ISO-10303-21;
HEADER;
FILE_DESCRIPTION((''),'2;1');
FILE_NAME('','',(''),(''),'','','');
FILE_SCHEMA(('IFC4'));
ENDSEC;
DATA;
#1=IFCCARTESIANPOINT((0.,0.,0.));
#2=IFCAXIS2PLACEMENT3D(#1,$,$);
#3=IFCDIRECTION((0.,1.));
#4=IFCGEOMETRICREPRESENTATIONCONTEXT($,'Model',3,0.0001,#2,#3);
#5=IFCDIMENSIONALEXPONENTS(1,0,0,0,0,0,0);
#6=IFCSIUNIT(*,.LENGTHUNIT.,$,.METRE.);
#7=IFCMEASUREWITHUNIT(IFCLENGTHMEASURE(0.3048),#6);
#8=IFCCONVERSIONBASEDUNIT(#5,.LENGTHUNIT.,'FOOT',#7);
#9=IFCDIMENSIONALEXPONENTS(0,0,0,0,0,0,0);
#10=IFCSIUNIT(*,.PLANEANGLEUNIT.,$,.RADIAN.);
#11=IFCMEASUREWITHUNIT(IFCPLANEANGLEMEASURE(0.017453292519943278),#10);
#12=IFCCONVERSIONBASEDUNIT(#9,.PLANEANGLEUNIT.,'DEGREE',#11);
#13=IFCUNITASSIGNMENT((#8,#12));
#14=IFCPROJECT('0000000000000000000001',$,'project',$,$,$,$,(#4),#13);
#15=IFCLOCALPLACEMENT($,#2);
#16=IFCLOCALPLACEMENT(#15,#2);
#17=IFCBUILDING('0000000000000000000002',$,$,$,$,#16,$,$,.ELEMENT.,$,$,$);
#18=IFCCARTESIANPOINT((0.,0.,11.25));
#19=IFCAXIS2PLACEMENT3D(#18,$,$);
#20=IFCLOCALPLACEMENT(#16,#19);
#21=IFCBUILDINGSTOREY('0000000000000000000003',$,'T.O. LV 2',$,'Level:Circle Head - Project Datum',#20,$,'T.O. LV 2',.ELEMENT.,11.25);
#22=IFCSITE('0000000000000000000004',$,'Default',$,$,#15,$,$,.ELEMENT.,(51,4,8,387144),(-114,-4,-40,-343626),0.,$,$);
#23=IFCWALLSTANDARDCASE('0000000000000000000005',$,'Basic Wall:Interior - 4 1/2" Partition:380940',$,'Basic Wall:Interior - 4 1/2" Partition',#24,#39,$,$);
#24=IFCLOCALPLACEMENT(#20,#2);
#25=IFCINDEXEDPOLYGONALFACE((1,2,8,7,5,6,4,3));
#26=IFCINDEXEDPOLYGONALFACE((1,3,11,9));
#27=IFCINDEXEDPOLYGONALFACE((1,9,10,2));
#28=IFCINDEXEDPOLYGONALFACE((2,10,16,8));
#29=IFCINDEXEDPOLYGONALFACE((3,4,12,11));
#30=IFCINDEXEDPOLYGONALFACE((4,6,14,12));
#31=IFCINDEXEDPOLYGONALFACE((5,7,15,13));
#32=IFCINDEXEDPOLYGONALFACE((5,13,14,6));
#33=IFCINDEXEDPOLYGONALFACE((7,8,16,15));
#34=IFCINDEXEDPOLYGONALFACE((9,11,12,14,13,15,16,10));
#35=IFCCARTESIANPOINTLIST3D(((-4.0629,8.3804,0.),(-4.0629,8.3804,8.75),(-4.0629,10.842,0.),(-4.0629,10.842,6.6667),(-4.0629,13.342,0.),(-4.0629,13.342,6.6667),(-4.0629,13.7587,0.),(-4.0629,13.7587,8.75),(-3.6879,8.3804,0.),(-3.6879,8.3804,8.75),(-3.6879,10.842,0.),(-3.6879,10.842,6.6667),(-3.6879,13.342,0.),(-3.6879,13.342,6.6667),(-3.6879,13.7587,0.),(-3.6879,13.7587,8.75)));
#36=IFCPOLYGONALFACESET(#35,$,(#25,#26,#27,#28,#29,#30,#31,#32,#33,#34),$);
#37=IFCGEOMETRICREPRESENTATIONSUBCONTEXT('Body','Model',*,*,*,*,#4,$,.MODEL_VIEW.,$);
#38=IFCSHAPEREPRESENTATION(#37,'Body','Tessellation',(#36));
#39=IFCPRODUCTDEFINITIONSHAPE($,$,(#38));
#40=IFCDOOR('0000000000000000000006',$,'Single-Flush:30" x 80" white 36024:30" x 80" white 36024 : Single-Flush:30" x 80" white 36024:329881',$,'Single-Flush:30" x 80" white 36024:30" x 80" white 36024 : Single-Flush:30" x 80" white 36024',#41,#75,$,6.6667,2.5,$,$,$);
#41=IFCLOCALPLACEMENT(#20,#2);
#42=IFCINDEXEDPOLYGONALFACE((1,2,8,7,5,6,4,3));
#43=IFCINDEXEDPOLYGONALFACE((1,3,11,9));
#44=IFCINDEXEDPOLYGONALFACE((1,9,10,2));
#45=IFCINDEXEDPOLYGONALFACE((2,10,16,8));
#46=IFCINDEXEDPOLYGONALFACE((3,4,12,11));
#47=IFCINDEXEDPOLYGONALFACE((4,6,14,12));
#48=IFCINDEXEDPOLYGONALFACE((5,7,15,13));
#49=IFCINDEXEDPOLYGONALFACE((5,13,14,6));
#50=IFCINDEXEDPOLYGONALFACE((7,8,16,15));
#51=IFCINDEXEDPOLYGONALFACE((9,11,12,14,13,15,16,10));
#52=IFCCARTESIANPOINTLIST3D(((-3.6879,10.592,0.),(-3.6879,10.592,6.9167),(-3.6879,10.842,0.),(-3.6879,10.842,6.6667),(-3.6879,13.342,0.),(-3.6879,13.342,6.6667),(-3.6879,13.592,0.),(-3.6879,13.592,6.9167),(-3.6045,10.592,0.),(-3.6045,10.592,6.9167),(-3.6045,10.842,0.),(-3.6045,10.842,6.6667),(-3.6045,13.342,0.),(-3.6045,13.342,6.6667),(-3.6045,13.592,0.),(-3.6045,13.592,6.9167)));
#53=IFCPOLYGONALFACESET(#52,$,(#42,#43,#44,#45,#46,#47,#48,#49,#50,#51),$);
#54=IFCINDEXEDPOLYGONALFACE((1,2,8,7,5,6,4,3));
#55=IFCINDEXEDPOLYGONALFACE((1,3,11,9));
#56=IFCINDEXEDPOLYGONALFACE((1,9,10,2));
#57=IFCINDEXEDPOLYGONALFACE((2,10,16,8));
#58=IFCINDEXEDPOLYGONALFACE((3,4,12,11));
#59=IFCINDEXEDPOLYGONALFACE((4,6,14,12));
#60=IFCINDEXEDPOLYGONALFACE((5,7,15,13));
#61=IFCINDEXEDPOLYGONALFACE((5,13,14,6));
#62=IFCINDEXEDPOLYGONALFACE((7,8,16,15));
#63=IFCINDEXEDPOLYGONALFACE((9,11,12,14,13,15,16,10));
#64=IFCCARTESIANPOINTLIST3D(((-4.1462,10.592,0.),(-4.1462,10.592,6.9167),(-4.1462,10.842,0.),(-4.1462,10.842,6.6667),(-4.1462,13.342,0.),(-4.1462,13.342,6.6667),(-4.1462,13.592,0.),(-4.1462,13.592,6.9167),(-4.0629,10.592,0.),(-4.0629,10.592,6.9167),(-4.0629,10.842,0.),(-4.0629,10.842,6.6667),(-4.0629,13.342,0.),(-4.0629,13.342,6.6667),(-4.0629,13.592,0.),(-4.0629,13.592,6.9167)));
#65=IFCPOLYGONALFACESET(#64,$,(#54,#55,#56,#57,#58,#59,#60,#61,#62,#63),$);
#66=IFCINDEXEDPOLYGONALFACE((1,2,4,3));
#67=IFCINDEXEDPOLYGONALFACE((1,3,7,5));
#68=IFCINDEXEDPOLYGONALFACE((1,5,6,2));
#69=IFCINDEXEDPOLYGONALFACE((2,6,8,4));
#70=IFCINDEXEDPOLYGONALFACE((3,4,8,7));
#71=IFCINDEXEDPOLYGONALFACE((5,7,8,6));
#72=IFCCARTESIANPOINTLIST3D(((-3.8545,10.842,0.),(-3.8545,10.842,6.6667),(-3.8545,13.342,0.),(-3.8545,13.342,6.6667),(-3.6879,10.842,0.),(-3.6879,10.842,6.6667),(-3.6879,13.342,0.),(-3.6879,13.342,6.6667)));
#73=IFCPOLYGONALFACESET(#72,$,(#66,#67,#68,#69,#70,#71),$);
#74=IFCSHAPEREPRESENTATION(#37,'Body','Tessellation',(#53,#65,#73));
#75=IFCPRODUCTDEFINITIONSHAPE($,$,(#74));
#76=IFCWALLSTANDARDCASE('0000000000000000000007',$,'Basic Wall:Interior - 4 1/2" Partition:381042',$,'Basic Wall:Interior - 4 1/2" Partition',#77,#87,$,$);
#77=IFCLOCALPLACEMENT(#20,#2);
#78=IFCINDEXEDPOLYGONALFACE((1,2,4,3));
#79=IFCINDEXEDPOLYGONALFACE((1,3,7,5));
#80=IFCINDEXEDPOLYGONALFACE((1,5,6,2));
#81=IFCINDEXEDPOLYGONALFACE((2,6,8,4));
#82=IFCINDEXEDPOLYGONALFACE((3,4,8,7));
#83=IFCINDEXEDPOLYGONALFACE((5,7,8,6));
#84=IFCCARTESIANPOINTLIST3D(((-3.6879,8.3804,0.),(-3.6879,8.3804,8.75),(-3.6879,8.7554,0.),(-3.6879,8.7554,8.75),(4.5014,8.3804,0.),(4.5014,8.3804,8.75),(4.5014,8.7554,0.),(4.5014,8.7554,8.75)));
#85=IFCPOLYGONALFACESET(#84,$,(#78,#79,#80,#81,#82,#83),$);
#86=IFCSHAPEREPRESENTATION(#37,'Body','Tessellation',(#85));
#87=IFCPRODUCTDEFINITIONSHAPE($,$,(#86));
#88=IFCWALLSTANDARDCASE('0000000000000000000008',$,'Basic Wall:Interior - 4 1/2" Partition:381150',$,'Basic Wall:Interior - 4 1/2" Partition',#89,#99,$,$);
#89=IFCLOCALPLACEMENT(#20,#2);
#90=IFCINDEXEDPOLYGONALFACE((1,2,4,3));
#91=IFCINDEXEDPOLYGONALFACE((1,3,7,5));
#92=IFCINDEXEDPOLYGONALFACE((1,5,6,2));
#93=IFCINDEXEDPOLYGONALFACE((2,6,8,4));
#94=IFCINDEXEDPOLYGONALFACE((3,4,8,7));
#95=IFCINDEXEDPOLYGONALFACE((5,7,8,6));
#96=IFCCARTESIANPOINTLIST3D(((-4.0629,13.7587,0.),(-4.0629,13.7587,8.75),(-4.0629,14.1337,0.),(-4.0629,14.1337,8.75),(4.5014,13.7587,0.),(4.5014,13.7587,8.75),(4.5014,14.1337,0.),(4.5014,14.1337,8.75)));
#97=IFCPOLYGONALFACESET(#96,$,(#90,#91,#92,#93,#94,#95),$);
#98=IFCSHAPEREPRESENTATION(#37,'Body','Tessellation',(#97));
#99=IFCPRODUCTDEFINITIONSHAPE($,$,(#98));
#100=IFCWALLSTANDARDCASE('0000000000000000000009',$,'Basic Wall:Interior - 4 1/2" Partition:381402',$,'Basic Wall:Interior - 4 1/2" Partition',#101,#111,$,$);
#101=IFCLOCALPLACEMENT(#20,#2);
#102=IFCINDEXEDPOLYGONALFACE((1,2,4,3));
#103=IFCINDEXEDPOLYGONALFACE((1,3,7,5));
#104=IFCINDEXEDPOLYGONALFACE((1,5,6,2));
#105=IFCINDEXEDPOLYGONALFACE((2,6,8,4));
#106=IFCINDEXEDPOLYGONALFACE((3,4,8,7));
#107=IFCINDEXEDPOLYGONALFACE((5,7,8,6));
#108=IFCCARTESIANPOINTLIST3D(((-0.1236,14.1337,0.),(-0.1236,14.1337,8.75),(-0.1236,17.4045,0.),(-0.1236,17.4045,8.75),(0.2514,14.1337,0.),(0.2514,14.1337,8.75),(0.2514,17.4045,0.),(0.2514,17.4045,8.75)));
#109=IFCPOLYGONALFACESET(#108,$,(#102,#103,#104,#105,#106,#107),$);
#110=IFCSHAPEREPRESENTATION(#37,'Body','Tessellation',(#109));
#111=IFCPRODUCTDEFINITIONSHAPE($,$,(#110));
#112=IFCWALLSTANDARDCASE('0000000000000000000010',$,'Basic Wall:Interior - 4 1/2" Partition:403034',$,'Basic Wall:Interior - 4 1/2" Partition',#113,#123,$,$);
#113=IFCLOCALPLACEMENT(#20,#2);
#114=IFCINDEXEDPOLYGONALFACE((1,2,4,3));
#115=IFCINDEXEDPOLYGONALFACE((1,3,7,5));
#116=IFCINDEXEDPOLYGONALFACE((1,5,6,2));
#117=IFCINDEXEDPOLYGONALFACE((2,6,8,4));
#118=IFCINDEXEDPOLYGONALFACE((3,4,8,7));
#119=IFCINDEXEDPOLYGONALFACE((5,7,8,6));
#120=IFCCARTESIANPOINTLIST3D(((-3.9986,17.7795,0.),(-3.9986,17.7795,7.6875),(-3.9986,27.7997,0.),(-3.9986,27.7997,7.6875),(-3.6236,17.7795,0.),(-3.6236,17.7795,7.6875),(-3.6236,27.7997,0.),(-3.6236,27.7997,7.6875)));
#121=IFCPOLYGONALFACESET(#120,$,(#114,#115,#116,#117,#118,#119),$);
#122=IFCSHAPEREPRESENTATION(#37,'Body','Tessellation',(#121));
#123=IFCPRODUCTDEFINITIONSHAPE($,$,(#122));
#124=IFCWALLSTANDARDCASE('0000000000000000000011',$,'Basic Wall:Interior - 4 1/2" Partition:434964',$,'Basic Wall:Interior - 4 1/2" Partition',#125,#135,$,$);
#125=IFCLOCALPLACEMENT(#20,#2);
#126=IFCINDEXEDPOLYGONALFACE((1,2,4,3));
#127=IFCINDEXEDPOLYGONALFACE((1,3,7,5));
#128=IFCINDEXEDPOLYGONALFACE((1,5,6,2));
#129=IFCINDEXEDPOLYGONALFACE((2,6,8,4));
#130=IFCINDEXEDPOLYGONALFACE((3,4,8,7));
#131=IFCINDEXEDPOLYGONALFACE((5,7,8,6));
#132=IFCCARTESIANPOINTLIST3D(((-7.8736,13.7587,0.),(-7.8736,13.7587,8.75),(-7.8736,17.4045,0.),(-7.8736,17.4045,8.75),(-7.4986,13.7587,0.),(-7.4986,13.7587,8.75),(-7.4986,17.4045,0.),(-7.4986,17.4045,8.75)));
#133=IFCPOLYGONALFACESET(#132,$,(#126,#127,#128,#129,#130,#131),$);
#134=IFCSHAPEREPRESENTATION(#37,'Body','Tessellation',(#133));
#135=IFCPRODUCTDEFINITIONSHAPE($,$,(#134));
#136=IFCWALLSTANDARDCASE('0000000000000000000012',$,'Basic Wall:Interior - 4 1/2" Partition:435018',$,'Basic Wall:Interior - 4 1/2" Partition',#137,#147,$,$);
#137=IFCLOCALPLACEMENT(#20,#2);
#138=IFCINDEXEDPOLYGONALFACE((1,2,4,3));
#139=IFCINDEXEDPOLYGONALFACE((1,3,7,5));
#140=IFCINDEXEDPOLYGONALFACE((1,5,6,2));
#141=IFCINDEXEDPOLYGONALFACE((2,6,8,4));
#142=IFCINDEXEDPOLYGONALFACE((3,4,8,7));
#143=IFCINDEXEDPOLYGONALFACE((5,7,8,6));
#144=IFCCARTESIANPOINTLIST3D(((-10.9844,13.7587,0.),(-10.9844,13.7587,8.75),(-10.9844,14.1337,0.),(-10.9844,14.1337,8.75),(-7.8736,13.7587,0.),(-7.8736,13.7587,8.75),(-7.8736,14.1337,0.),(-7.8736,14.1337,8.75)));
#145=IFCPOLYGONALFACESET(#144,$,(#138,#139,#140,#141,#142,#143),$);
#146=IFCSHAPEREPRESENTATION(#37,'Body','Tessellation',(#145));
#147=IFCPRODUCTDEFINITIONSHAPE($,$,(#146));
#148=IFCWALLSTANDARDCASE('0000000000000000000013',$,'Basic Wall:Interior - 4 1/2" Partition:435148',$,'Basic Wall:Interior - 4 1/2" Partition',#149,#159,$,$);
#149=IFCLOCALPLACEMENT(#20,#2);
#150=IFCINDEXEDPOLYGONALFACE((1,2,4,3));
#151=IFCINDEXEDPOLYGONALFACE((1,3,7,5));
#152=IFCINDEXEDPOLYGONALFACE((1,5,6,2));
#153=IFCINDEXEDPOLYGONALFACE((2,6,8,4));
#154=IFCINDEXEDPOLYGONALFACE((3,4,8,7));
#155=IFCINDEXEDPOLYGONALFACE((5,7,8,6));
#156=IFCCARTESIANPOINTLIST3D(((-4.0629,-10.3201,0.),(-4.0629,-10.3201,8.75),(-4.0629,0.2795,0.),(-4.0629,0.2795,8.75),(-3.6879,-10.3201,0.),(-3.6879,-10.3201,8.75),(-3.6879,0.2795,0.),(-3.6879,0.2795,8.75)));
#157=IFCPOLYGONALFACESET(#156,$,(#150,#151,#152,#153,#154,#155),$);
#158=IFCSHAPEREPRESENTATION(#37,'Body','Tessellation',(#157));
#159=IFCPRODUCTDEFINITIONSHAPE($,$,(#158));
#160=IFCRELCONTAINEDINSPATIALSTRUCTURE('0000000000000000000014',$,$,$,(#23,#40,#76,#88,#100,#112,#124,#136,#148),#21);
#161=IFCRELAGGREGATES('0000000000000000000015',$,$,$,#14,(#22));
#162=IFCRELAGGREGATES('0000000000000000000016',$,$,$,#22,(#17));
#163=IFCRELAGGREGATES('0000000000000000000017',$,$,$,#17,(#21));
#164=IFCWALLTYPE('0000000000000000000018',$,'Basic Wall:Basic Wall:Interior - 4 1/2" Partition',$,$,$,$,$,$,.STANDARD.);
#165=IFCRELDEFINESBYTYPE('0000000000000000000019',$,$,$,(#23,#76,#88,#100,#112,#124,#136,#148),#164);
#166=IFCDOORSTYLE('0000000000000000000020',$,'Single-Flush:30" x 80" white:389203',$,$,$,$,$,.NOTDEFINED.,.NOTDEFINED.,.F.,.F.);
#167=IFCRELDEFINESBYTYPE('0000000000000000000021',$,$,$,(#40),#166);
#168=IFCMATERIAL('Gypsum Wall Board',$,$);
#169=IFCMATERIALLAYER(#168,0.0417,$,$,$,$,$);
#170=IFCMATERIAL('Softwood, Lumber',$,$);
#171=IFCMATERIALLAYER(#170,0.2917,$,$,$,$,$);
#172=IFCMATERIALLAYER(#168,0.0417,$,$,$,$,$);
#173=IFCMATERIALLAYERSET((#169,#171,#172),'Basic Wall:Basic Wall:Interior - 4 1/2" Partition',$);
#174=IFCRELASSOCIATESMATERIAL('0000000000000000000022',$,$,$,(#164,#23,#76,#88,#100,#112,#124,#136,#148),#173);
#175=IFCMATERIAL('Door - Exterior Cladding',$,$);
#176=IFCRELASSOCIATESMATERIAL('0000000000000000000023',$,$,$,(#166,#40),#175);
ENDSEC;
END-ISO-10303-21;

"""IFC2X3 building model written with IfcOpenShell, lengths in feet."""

from ifc_helpers import new_model, entity, si_unit, converted_unit, direction, frame, frame_2d, origin, origin_2d_with_axis, place, context, subcontext, project, spatial, polyline, rectangle, outline, extrude, source, transform, mapped, material, layer, layer_set, layer_usage, type_object, type_shapes, element, fill, save


model = new_model("IFC2X3")

# Units and contexts
model_context = context("Model", 3, precision=0.0001, world=origin(), true_north=direction((0.0, 1.0)))
body_context = subcontext(model_context, "Body", "Model", "MODEL_VIEW")
ifc_project = project(units=[converted_unit("LENGTHUNIT", "FOOT", entity("IfcLengthMeasure", 0.3048), si_unit("LENGTHUNIT", "METRE"), dimensions=[1, 0, 0, 0, 0, 0, 0]), converted_unit("PLANEANGLEUNIT", "DEGREE", entity("IfcPlaneAngleMeasure", 0.017453292519943278), si_unit("PLANEANGLEUNIT", "RADIAN"), dimensions=[0, 0, 0, 0, 0, 0, 0])], contexts=[model_context])

# Site, building, storey
site_placement = place(None, origin())
site = spatial("IfcSite", under=ifc_project, at=site_placement, Name="Default", CompositionType="ELEMENT", RefLatitude=(51, 4, 8, 387144), RefLongitude=(-114, -4, -40, -343626), RefElevation=0.0)
building_placement = place(site_placement, origin())
building = spatial("IfcBuilding", under=site, at=building_placement, CompositionType="ELEMENT")
storey_placement = place(building_placement, frame((0.0, 0.0, 11.25)))
storey = spatial("IfcBuildingStorey", under=building, at=storey_placement, Name="T.O. LV 2", ObjectType="Level:Circle Head - Project Datum", LongName="T.O. LV 2", CompositionType="ELEMENT", Elevation=11.25)

# Shared definitions
ifc_material_1 = material(Name="Gypsum Wall Board")
ifc_layer_1 = layer(ifc_material_1, 0.0417)
ifc_material_2 = material(Name="Softwood, Lumber")
ifc_layer_2 = layer(ifc_material_2, 0.2917)
ifc_layer_3 = layer(ifc_material_1, 0.0417)
ifc_layer_set_1 = layer_set([ifc_layer_1, ifc_layer_2, ifc_layer_3], Name="Basic Wall:Basic Wall:Interior - 4 1/2\" Partition")
wall_type_1 = type_object("IfcWallType", Name="Basic Wall:Basic Wall:Interior - 4 1/2\" Partition", PredefinedType="STANDARD", material=ifc_layer_set_1)

# Wall, opening, door
ifc_layer_usage_1 = layer_usage(ifc_layer_set_1, "AXIS2", "NEGATIVE", 0.1875)
wall_1_placement = place(storey_placement, frame((-3.8754, 13.7587, 0.0), z_axis=(0.0, 0.0, 1.0), x_axis=(0.0, -1.0, 0.0)))
wall_1 = element("IfcWallStandardCase", 1, at=wall_1_placement, inside=storey, type_object=wall_type_1, material=ifc_layer_usage_1, Name="Basic Wall:Interior - 4 1/2\" Partition:380940", ObjectType="Basic Wall:Interior - 4 1/2\" Partition", context=body_context, shape_type="SweptSolid", body=[
    extrude(rectangle(XDim=5.3783, YDim=0.375, at=frame_2d((2.6891, 0.0), x_axis=(1.0, 0.0))), origin(), (0.0, 0.0, 1.0), 8.75),
])
opening_1_placement = place(wall_1_placement, frame((13.7587, 3.8754, 0.0), z_axis=(0.0, 0.0, 1.0), x_axis=(0.0, 1.0, 0.0)))
opening_1 = element("IfcOpeningElement", 2, at=opening_1_placement, cuts=wall_1, ObjectType="Opening", context=body_context, shape_type="SweptSolid", body=[
    extrude(rectangle(XDim=6.6667, YDim=2.5, at=frame_2d((0.0, 0.0), x_axis=(1.0, 0.0))), frame((-4.0666, 12.092, 3.3333), z_axis=(1.0, 0.0, 0.0), x_axis=(0.0, 0.0, 1.0)), (0.0, 0.0, 1.0), 0.3825),
])
ifc_material_3 = material(Name="Door - Exterior Cladding")
door_style_1 = type_object("IfcDoorStyle", Name="Single-Flush:30\" x 80\" white:389203", ConstructionType="NOTDEFINED", OperationType="NOTDEFINED", ParameterTakesPrecedence=False, Sizeable=False, material=ifc_material_3)
shared_shape_1 = source(origin(), body_context, "Body", "SweptSolid", [
    extrude(outline(polyline([(-1.5, -3.5208), (1.5, -3.5208), (1.5, 3.3958), (1.25, 3.3958), (1.25, -3.2708), (-1.25, -3.2708), (-1.25, 3.3958), (-1.5, 3.3958), (-1.5, -3.5208)])), frame((1.25, -0.0038, 3.3958), z_axis=(0.0, 1.0, 0.0), x_axis=(1.0, 0.0, 0.0)), (0.0, 0.0, 1.0), 0.0833),
    extrude(outline(polyline([(-3.3958, -1.5), (3.5208, -1.5), (3.5208, 1.5), (-3.3958, 1.5), (-3.3958, 1.25), (3.2708, 1.25), (3.2708, -1.25), (-3.3958, -1.25), (-3.3958, -1.5)])), frame((1.25, -0.4621, 3.3958), z_axis=(0.0, 1.0, 0.0), x_axis=(0.0, 0.0, 1.0)), (0.0, 0.0, 1.0), 0.0833),
    extrude(rectangle(XDim=0.1667, YDim=2.5, at=origin_2d_with_axis()), frame((1.25, -0.0871, 0.0), z_axis=(0.0, 0.0, 1.0), x_axis=(0.0, 1.0, 0.0)), (0.0, 0.0, 1.0), 6.6667),
])
type_shapes(door_style_1, [shared_shape_1])
door_1_placement = place(opening_1_placement, frame((-3.6841, 13.342, 0.0), z_axis=(0.0, 0.0, 1.0), x_axis=(0.0, -1.0, 0.0)))
door_1 = element("IfcDoor", 3, at=door_1_placement, inside=storey, type_object=door_style_1, material=ifc_material_3, Name="Single-Flush:30\" x 80\" white 36024:30\" x 80\" white 36024 : Single-Flush:30\" x 80\" white 36024:329881", ObjectType="Single-Flush:30\" x 80\" white 36024:30\" x 80\" white 36024 : Single-Flush:30\" x 80\" white 36024", OverallHeight=6.6667, OverallWidth=2.5, context=body_context, shape_type="MappedRepresentation", body=[
    mapped(shared_shape_1, transform((0.0, 0.0, 0.0), scale=1.0)),
])
fill(opening_1, door_1)

# Walls
ifc_layer_usage_2 = layer_usage(ifc_layer_set_1, "AXIS2", "NEGATIVE", 0.1875)
wall_2_placement = place(storey_placement, frame((-3.6879, 8.5679, 0.0)))
element("IfcWallStandardCase", 4, at=wall_2_placement, inside=storey, type_object=wall_type_1, material=ifc_layer_usage_2, Name="Basic Wall:Interior - 4 1/2\" Partition:381042", ObjectType="Basic Wall:Interior - 4 1/2\" Partition", context=body_context, shape_type="SweptSolid", body=[
    extrude(rectangle(XDim=8.1893, YDim=0.375, at=frame_2d((4.0947, 0.0), x_axis=(-1.0, 0.0))), origin(), (0.0, 0.0, 1.0), 8.75),
])
ifc_layer_usage_3 = layer_usage(ifc_layer_set_1, "AXIS2", "NEGATIVE", 0.1875)
wall_3_placement = place(storey_placement, frame((-4.0629, 13.9462, 0.0)))
element("IfcWallStandardCase", 5, at=wall_3_placement, inside=storey, type_object=wall_type_1, material=ifc_layer_usage_3, Name="Basic Wall:Interior - 4 1/2\" Partition:381150", ObjectType="Basic Wall:Interior - 4 1/2\" Partition", context=body_context, shape_type="SweptSolid", body=[
    extrude(rectangle(XDim=8.5643, YDim=0.375, at=frame_2d((4.2822, 0.0), x_axis=(-1.0, 0.0))), origin(), (0.0, 0.0, 1.0), 8.75),
])
ifc_layer_usage_4 = layer_usage(ifc_layer_set_1, "AXIS2", "NEGATIVE", 0.1875)
wall_4_placement = place(storey_placement, frame((0.0639, 17.4045, 0.0), z_axis=(0.0, 0.0, 1.0), x_axis=(0.0, -1.0, 0.0)))
element("IfcWallStandardCase", 6, at=wall_4_placement, inside=storey, type_object=wall_type_1, material=ifc_layer_usage_4, Name="Basic Wall:Interior - 4 1/2\" Partition:381402", ObjectType="Basic Wall:Interior - 4 1/2\" Partition", context=body_context, shape_type="SweptSolid", body=[
    extrude(rectangle(XDim=3.2708, YDim=0.375, at=frame_2d((1.6354, 0.0), x_axis=(-1.0, 0.0))), origin(), (0.0, 0.0, 1.0), 8.75),
])
ifc_layer_usage_5 = layer_usage(ifc_layer_set_1, "AXIS2", "NEGATIVE", 0.1875)
wall_5_placement = place(storey_placement, frame((-3.8111, 27.7997, 0.0), z_axis=(0.0, 0.0, 1.0), x_axis=(0.0, -1.0, 0.0)))
element("IfcWallStandardCase", 7, at=wall_5_placement, inside=storey, type_object=wall_type_1, material=ifc_layer_usage_5, Name="Basic Wall:Interior - 4 1/2\" Partition:403034", ObjectType="Basic Wall:Interior - 4 1/2\" Partition", context=body_context, shape_type="SweptSolid", body=[
    extrude(rectangle(XDim=10.0202, YDim=0.375, at=frame_2d((5.0101, 0.0), x_axis=(-1.0, 0.0))), origin(), (0.0, 0.0, 1.0), 7.6875),
])
ifc_layer_usage_6 = layer_usage(ifc_layer_set_1, "AXIS2", "NEGATIVE", 0.1875)
wall_6_placement = place(storey_placement, frame((-7.6861, 17.4045, 0.0), z_axis=(0.0, 0.0, 1.0), x_axis=(0.0, -1.0, 0.0)))
element("IfcWallStandardCase", 8, at=wall_6_placement, inside=storey, type_object=wall_type_1, material=ifc_layer_usage_6, Name="Basic Wall:Interior - 4 1/2\" Partition:434964", ObjectType="Basic Wall:Interior - 4 1/2\" Partition", context=body_context, shape_type="SweptSolid", body=[
    extrude(rectangle(XDim=3.6458, YDim=0.375, at=frame_2d((1.8229, 0.0), x_axis=(-1.0, 0.0))), origin(), (0.0, 0.0, 1.0), 8.75),
])
ifc_layer_usage_7 = layer_usage(ifc_layer_set_1, "AXIS2", "NEGATIVE", 0.1875)
wall_7_placement = place(storey_placement, frame((-7.8736, 13.9462, 0.0), z_axis=(0.0, 0.0, 1.0), x_axis=(-1.0, 0.0, 0.0)))
element("IfcWallStandardCase", 9, at=wall_7_placement, inside=storey, type_object=wall_type_1, material=ifc_layer_usage_7, Name="Basic Wall:Interior - 4 1/2\" Partition:435018", ObjectType="Basic Wall:Interior - 4 1/2\" Partition", context=body_context, shape_type="SweptSolid", body=[
    extrude(rectangle(XDim=3.1108, YDim=0.375, at=frame_2d((1.5554, 0.0), x_axis=(-1.0, 0.0))), origin(), (0.0, 0.0, 1.0), 8.75),
])
ifc_layer_usage_8 = layer_usage(ifc_layer_set_1, "AXIS2", "NEGATIVE", 0.1875)
wall_8_placement = place(storey_placement, frame((-3.8754, 0.2795, 0.0), z_axis=(0.0, 0.0, 1.0), x_axis=(0.0, -1.0, 0.0)))
element("IfcWallStandardCase", 10, at=wall_8_placement, inside=storey, type_object=wall_type_1, material=ifc_layer_usage_8, Name="Basic Wall:Interior - 4 1/2\" Partition:435148", ObjectType="Basic Wall:Interior - 4 1/2\" Partition", context=body_context, shape_type="SweptSolid", body=[
    extrude(rectangle(XDim=10.5996, YDim=0.375, at=frame_2d((5.2998, 0.0), x_axis=(-1.0, 0.0))), origin(), (0.0, 0.0, 1.0), 8.75),
])

save(model, "model.ifc")
